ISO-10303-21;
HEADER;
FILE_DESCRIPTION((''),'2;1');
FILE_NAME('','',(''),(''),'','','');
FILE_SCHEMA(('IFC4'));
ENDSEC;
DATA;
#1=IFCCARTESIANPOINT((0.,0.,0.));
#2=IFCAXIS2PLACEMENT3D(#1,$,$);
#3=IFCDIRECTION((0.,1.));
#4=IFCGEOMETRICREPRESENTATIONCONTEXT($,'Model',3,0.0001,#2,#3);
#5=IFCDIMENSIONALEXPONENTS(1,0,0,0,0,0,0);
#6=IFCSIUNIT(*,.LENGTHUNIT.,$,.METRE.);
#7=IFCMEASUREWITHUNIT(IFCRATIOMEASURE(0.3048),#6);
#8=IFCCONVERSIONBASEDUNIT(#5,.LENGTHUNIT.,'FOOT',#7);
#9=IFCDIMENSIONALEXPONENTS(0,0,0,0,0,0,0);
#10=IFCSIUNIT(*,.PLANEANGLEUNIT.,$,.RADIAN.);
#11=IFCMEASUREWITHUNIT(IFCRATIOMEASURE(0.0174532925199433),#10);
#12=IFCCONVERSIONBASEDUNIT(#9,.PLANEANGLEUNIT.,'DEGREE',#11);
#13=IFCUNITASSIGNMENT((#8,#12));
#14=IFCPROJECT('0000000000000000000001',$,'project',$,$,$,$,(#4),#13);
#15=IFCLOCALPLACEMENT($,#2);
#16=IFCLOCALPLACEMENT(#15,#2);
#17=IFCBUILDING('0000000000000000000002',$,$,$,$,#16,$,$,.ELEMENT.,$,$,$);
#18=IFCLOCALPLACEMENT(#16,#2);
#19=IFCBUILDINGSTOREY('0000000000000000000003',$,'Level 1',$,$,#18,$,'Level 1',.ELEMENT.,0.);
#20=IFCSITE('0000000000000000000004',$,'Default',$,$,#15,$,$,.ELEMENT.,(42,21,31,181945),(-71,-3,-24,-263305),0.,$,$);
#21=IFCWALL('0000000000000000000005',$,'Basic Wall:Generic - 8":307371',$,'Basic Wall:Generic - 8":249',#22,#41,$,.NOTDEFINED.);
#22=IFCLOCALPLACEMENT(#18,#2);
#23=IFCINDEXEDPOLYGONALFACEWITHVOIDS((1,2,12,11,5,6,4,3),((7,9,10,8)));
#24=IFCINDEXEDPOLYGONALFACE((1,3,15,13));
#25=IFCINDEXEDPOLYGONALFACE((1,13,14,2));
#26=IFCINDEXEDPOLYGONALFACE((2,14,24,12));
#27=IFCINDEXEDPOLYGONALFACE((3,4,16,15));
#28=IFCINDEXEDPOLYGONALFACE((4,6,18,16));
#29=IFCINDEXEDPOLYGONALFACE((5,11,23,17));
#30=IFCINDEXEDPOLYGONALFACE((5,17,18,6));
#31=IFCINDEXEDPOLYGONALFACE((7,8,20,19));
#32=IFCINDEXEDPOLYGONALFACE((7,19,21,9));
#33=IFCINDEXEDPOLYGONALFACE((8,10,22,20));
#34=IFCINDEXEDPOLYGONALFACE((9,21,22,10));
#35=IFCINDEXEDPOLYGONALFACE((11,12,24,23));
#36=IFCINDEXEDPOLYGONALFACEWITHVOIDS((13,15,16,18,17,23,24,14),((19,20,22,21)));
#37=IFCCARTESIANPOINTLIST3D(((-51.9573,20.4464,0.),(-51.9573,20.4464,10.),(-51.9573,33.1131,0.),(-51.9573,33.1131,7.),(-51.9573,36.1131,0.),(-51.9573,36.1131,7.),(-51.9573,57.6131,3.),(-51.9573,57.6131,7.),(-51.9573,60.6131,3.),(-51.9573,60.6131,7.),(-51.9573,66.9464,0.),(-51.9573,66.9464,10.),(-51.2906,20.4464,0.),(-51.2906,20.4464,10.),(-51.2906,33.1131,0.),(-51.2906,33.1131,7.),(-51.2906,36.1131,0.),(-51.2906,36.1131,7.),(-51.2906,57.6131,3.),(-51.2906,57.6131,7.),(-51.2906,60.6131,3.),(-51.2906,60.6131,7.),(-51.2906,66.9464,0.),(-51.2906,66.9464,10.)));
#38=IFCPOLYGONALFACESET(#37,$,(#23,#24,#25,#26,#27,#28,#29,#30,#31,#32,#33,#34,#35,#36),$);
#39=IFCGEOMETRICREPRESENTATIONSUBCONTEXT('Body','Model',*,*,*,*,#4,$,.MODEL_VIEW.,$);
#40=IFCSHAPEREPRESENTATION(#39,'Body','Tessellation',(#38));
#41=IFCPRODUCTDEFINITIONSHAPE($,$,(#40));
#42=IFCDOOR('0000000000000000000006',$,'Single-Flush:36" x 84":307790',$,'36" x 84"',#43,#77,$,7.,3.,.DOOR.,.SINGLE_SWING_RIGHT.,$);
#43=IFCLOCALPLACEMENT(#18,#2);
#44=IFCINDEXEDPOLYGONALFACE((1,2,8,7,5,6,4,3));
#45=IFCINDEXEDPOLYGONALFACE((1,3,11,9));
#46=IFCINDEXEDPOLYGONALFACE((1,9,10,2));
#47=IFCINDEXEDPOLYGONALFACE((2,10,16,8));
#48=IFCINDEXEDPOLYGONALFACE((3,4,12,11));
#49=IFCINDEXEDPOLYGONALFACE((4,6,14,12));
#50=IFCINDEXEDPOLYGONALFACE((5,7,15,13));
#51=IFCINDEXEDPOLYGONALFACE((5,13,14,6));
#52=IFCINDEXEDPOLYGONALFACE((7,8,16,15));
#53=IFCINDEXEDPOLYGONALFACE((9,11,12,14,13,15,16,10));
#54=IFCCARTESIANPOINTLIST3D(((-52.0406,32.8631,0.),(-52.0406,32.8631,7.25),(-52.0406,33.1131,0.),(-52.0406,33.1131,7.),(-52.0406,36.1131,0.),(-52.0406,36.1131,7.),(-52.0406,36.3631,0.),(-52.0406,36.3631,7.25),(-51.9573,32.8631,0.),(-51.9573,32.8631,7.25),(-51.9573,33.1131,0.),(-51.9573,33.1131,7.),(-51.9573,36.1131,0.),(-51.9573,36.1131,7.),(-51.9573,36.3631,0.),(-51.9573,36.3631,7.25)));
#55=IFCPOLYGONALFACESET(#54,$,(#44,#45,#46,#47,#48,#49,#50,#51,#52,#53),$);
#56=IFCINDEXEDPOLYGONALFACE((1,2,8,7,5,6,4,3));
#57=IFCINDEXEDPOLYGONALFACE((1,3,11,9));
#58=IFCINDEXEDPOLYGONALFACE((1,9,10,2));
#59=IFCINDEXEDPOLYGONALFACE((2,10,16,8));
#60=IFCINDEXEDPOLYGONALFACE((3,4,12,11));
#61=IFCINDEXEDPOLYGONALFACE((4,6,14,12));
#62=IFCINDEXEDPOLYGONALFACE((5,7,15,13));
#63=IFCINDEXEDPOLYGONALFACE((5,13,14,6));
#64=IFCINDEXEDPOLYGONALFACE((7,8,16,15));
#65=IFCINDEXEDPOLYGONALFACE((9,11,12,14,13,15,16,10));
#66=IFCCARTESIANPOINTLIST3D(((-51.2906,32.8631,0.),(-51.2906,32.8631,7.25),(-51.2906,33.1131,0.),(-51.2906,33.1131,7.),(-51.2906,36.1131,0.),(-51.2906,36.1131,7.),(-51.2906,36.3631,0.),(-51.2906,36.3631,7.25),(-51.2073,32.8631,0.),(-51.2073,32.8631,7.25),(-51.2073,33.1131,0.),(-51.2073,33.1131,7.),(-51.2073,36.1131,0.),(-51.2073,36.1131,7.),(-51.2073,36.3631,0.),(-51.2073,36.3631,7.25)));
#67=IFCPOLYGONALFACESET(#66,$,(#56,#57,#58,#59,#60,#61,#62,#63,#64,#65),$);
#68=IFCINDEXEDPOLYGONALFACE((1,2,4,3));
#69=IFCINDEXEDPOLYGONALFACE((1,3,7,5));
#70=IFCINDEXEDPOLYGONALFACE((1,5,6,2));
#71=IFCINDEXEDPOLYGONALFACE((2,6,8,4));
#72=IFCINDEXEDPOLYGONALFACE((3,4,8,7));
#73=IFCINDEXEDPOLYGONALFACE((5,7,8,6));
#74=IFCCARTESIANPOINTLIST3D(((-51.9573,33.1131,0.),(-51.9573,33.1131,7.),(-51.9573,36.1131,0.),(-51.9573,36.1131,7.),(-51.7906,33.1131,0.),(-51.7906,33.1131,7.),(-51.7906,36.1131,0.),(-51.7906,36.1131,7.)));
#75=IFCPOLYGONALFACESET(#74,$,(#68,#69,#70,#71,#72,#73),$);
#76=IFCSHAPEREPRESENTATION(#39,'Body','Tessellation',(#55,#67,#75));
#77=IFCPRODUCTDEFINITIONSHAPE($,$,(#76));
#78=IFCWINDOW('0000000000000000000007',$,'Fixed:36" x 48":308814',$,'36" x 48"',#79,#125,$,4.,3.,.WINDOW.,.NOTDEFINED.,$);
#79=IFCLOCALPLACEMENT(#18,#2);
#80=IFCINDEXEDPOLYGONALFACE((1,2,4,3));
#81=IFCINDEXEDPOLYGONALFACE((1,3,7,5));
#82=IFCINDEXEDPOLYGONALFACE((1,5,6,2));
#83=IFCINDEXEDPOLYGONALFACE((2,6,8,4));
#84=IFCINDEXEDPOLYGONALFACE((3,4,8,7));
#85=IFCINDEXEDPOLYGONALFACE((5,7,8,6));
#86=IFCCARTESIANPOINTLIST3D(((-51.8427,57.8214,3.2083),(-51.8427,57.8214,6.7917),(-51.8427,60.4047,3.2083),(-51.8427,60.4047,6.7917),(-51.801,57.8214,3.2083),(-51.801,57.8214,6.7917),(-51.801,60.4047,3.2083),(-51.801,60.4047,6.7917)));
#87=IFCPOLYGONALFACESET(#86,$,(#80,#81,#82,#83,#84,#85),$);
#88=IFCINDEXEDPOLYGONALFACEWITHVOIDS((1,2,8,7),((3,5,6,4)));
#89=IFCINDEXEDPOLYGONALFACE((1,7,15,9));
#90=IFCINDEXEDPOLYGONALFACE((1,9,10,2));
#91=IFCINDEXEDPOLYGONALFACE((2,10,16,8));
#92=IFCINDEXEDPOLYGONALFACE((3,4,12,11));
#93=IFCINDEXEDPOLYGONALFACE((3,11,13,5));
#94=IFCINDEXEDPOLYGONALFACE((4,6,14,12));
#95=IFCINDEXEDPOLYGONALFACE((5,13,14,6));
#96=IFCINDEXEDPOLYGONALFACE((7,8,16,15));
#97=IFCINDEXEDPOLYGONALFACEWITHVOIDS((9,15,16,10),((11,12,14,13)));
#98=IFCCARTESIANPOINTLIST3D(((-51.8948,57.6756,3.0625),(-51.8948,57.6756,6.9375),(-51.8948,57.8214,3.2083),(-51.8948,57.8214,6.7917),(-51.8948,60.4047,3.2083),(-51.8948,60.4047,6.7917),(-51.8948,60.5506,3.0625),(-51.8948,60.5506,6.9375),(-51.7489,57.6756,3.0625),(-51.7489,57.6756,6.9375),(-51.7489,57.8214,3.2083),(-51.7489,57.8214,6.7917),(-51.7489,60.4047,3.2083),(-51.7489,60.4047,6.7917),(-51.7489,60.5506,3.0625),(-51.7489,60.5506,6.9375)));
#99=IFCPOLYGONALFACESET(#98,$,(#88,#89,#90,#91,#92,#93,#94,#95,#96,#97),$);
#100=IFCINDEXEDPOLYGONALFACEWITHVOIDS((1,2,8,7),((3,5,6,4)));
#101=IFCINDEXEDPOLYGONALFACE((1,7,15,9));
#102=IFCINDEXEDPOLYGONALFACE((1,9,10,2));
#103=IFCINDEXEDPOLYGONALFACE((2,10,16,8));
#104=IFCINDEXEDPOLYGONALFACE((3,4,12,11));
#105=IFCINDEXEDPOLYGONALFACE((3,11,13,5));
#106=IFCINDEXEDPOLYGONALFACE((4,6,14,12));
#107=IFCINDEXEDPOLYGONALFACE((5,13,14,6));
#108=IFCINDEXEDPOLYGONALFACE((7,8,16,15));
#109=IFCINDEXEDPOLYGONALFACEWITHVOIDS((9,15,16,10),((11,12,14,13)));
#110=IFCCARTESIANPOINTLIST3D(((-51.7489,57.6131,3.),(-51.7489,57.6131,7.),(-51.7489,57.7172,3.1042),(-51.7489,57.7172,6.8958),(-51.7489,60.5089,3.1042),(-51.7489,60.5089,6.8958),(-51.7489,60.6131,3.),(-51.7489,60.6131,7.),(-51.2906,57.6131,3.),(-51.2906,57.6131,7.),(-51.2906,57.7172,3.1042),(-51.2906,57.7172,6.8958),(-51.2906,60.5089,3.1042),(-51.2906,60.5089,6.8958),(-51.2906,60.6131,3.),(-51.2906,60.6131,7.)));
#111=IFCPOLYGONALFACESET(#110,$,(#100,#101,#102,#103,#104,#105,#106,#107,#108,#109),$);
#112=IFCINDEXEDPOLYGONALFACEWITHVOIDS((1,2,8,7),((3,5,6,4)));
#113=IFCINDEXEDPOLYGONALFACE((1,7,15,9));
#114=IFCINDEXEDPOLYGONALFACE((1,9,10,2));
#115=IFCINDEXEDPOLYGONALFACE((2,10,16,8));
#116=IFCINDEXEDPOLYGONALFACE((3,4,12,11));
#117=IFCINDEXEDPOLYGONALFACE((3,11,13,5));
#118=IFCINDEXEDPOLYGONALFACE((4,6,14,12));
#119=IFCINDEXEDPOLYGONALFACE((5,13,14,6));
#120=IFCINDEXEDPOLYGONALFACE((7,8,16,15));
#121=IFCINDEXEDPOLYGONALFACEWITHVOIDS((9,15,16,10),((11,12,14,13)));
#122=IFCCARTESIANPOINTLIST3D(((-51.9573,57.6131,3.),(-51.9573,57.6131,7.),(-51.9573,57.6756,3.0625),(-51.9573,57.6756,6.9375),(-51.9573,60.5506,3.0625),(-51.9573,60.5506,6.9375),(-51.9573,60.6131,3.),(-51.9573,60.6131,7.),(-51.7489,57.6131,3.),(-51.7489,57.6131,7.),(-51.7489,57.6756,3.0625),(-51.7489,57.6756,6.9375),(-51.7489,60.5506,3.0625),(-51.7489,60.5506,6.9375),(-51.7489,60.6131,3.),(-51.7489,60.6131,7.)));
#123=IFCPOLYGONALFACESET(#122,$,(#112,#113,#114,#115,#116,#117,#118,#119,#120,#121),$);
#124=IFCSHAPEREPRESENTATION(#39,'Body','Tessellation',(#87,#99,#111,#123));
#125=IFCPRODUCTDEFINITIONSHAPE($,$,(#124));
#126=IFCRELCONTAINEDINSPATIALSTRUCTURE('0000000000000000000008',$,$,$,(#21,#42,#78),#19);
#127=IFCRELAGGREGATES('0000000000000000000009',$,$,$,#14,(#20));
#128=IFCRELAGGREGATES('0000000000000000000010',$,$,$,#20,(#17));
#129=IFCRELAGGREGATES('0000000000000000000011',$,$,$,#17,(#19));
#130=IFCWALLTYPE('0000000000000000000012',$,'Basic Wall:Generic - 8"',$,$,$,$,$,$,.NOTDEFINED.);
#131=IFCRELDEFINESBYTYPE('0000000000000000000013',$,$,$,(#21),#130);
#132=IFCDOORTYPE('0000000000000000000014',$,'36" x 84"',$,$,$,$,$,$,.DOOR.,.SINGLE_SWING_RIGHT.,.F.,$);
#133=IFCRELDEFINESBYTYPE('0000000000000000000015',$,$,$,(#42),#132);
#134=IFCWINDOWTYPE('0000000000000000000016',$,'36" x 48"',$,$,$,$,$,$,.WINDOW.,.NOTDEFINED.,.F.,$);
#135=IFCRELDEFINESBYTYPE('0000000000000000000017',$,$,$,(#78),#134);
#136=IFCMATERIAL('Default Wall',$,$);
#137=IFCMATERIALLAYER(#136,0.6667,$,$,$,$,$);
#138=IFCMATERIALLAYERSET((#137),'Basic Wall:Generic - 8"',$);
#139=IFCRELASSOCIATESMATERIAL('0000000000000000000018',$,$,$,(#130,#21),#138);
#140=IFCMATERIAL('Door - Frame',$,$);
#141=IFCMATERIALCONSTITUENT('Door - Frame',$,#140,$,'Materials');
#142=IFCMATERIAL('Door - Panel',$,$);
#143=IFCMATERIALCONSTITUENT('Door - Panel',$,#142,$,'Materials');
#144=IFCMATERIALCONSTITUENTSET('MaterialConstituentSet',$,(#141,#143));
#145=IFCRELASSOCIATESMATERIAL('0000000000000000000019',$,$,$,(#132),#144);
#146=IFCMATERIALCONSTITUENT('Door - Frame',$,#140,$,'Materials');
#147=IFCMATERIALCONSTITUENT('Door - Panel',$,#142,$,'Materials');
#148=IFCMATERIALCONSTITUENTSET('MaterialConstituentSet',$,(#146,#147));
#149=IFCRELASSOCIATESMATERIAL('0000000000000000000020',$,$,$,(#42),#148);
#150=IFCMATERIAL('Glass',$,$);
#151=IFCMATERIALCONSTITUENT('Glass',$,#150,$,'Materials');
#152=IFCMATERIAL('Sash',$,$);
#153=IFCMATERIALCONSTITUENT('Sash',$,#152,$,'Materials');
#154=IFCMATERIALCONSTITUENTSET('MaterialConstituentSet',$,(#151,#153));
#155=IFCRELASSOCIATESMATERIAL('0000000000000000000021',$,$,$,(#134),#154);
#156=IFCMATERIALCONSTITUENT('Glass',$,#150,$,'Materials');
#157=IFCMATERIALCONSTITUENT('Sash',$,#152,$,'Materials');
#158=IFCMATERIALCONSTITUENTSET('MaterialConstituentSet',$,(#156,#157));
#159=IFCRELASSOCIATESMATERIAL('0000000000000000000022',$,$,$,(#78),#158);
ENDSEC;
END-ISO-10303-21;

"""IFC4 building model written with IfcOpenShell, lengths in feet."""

from ifc_helpers import new_model, entity, si_unit, converted_unit, direction, frame, frame_2d, origin, place, context, subcontext, project, spatial, polyline, rectangle, outline, extrude, source, transform, mapped, material, layer, layer_set, layer_usage, constituent, constituent_set, type_object, type_shapes, element, fill, save


model = new_model("IFC4")

# Units and contexts
model_context = context("Model", 3, precision=0.0001, world=origin(), true_north=direction((0.0, 1.0)))
body_context = subcontext(model_context, "Body", "Model", "MODEL_VIEW")
ifc_project = project(units=[converted_unit("LENGTHUNIT", "FOOT", entity("IfcRatioMeasure", 0.3048), si_unit("LENGTHUNIT", "METRE"), dimensions=[1, 0, 0, 0, 0, 0, 0]), converted_unit("PLANEANGLEUNIT", "DEGREE", entity("IfcRatioMeasure", 0.0174532925199433), si_unit("PLANEANGLEUNIT", "RADIAN"), dimensions=[0, 0, 0, 0, 0, 0, 0])], contexts=[model_context])

# Site, building, storey
site_placement = place(None, origin())
site = spatial("IfcSite", under=ifc_project, at=site_placement, Name="Default", CompositionType="ELEMENT", RefLatitude=(42, 21, 31, 181945), RefLongitude=(-71, -3, -24, -263305), RefElevation=0.0)
building_placement = place(site_placement, origin())
building = spatial("IfcBuilding", under=site, at=building_placement, CompositionType="ELEMENT")
storey_placement = place(building_placement, origin())
storey = spatial("IfcBuildingStorey", under=building, at=storey_placement, Name="Level 1", LongName="Level 1", CompositionType="ELEMENT", Elevation=0.0)

# Wall, openings, door, window
ifc_material_1 = material(Name="Default Wall")
ifc_layer = layer(ifc_material_1, 0.6667)
ifc_layer_set = layer_set([ifc_layer], Name="Basic Wall:Generic - 8\"")
ifc_layer_usage_1 = layer_usage(ifc_layer_set, "AXIS2", "NEGATIVE", 0.3333)
wall_type = type_object("IfcWallType", Name="Basic Wall:Generic - 8\"", PredefinedType="NOTDEFINED", material=ifc_layer_set)
wall_1_placement = place(storey_placement, frame((-51.6239, 66.9464, 0.0), z_axis=(0.0, 0.0, 1.0), x_axis=(0.0, -1.0, 0.0)))
wall_1 = element("IfcWall", 1, at=wall_1_placement, inside=storey, type_object=wall_type, material=ifc_layer_usage_1, Name="Basic Wall:Generic - 8\":307371", ObjectType="Basic Wall:Generic - 8\":249", PredefinedType="NOTDEFINED", context=body_context, shape_type="SweptSolid", body=[
    extrude(rectangle(XDim=46.5, YDim=0.6667, at=frame_2d((23.25, 0.0), x_axis=(-1.0, 0.0))), origin(), (0.0, 0.0, 1.0), 10.0),
])
opening_1_placement = place(wall_1_placement, frame((33.8333, 0.3333, 0.0)))
opening_1 = element("IfcOpeningElement", 2, at=opening_1_placement, cuts=wall_1, ObjectType="Opening", PredefinedType="OPENING", context=body_context, shape_type="SweptSolid", body=[
    extrude(rectangle(XDim=3.0, YDim=7.0, at=frame_2d((3.5, 1.5), x_axis=(0.0, 1.0))), frame((0.0, 0.0, 0.0), z_axis=(0.0, -1.0, 0.0), x_axis=(0.0, 0.0, 1.0)), (0.0, 0.0, 1.0), 0.6667),
])
opening_2_placement = place(wall_1_placement, frame((9.3333, 0.3333, 3.0)))
opening_2 = element("IfcOpeningElement", 3, at=opening_2_placement, cuts=wall_1, ObjectType="Opening", PredefinedType="OPENING", context=body_context, shape_type="SweptSolid", body=[
    extrude(rectangle(XDim=4.0, YDim=3.0, at=frame_2d((2.0, 1.5), x_axis=(-1.0, 0.0))), frame((0.0, 0.0, 0.0), z_axis=(0.0, -1.0, 0.0), x_axis=(0.0, 0.0, 1.0)), (0.0, 0.0, 1.0), 0.6667),
])
ifc_material_2 = material(Name="Door - Frame")
ifc_constituent_1 = constituent(ifc_material_2, Name="Door - Frame", Category="Materials")
ifc_material_3 = material(Name="Door - Panel")
ifc_constituent_2 = constituent(ifc_material_3, Name="Door - Panel", Category="Materials")
ifc_constituent_set_1 = constituent_set(constituents=[ifc_constituent_1, ifc_constituent_2], Name="MaterialConstituentSet")
ifc_constituent_3 = constituent(ifc_material_2, Name="Door - Frame", Category="Materials")
ifc_constituent_4 = constituent(ifc_material_3, Name="Door - Panel", Category="Materials")
ifc_constituent_set_2 = constituent_set(constituents=[ifc_constituent_3, ifc_constituent_4], Name="MaterialConstituentSet")
door_type = type_object("IfcDoorType", Name="36\" x 84\"", OperationType="SINGLE_SWING_RIGHT", ParameterTakesPrecedence=False, PredefinedType="DOOR", material=ifc_constituent_set_2)
shared_shape_1 = source(origin(), body_context, "Body", "SweptSolid", [
    extrude(outline(polyline([(-1.75, -3.6875), (1.75, -3.6875), (1.75, 3.5625), (1.5, 3.5625), (1.5, -3.4375), (-1.5, -3.4375), (-1.5, 3.5625), (-1.75, 3.5625), (-1.75, -3.6875)])), frame((1.5, 0.6667, 3.5625), z_axis=(0.0, 1.0, 0.0), x_axis=(1.0, 0.0, 0.0)), (0.0, 0.0, 1.0), 0.0833),
    extrude(outline(polyline([(-3.6875, -1.75), (3.5625, -1.75), (3.5625, -1.5), (-3.4375, -1.5), (-3.4375, 1.5), (3.5625, 1.5), (3.5625, 1.75), (-3.6875, 1.75), (-3.6875, -1.75)])), frame((1.5, -0.0833, 3.5625), z_axis=(0.0, 1.0, 0.0), x_axis=(0.0, 0.0, -1.0)), (0.0, 0.0, 1.0), 0.0833),
    extrude(rectangle(XDim=0.1667, YDim=3.0, at=frame_2d((0.0, 0.0), x_axis=(1.0, 0.0))), frame((1.5, 0.5833, 0.0), z_axis=(0.0, 0.0, 1.0), x_axis=(0.0, 1.0, 0.0)), (0.0, 0.0, 1.0), 7.0),
])
type_shapes(door_type, [shared_shape_1])
door_1_placement = place(opening_1_placement, frame((0.0, 0.0, 0.0), z_axis=(0.0, 0.0, 1.0), x_axis=(-1.0, 0.0, 0.0)))
door_1 = element("IfcDoor", 4, at=door_1_placement, inside=storey, type_object=door_type, material=ifc_constituent_set_1, Name="Single-Flush:36\" x 84\":307790", ObjectType="36\" x 84\"", OperationType="SINGLE_SWING_RIGHT", OverallHeight=7.0, OverallWidth=3.0, PredefinedType="DOOR", context=body_context, shape_type="MappedRepresentation", body=[
    mapped(shared_shape_1, transform((0.0, 0.0, 0.0), scale=1.0)),
])
fill(opening_1, door_1)
ifc_material_4 = material(Name="Glass")
ifc_constituent_5 = constituent(ifc_material_4, Name="Glass", Category="Materials")
ifc_material_5 = material(Name="Sash")
ifc_constituent_6 = constituent(ifc_material_5, Name="Sash", Category="Materials")
ifc_constituent_set_3 = constituent_set(constituents=[ifc_constituent_5, ifc_constituent_6], Name="MaterialConstituentSet")
ifc_constituent_7 = constituent(ifc_material_4, Name="Glass", Category="Materials")
ifc_constituent_8 = constituent(ifc_material_5, Name="Sash", Category="Materials")
ifc_constituent_set_4 = constituent_set(constituents=[ifc_constituent_7, ifc_constituent_8], Name="MaterialConstituentSet")
window_type_1 = type_object("IfcWindowType", Name="36\" x 48\"", ParameterTakesPrecedence=False, PartitioningType="NOTDEFINED", PredefinedType="WINDOW", material=ifc_constituent_set_4)
shared_shape_2 = source(origin(), body_context, "Body", "SweptSolid", [
    extrude(rectangle(XDim=0.0417, YDim=2.5833, at=frame_2d((0.0, 0.0), x_axis=(1.0, 0.0))), frame((1.5, 0.5312, 0.2083), z_axis=(0.0, 0.0, 1.0), x_axis=(0.0, 1.0, 0.0)), (0.0, 0.0, 1.0), 3.5833),
    extrude(outline(polyline([(-1.4375, -1.9375), (1.4375, -1.9375), (1.4375, 1.9375), (-1.4375, 1.9375), (-1.4375, -1.9375)]), holes=[polyline([(-1.2917, -1.7917), (-1.2917, 1.7917), (1.2917, 1.7917), (1.2917, -1.7917), (-1.2917, -1.7917)])]), frame((1.5, 0.4583, 2.0), z_axis=(0.0, 1.0, 0.0), x_axis=(1.0, 0.0, 0.0)), (0.0, 0.0, 1.0), 0.1458),
    extrude(outline(polyline([(-1.5, -2.0), (1.5, -2.0), (1.5, 2.0), (-1.5, 2.0), (-1.5, -2.0)]), holes=[polyline([(-1.3958, -1.8958), (-1.3958, 1.8958), (1.3958, 1.8958), (1.3958, -1.8958), (-1.3958, -1.8958)])]), frame((1.5, 0.0, 2.0), z_axis=(0.0, 1.0, 0.0), x_axis=(1.0, 0.0, 0.0)), (0.0, 0.0, 1.0), 0.4583),
    extrude(outline(polyline([(-2.0, -1.5), (2.0, -1.5), (2.0, 1.5), (-2.0, 1.5), (-2.0, -1.5)]), holes=[polyline([(-1.9375, -1.4375), (-1.9375, 1.4375), (1.9375, 1.4375), (1.9375, -1.4375), (-1.9375, -1.4375)])]), frame((1.5, 0.4583, 2.0), z_axis=(0.0, 1.0, 0.0), x_axis=(0.0, 0.0, -1.0)), (0.0, 0.0, 1.0), 0.2083),
])
type_shapes(window_type_1, [shared_shape_2])
window_1_placement = place(opening_2_placement, frame((0.0, 0.0, 0.0), z_axis=(0.0, 0.0, 1.0), x_axis=(-1.0, 0.0, 0.0)))
window_1 = element("IfcWindow", 5, at=window_1_placement, inside=storey, type_object=window_type_1, material=ifc_constituent_set_3, Name="Fixed:36\" x 48\":308814", ObjectType="36\" x 48\"", OverallHeight=4.0, OverallWidth=3.0, PartitioningType="NOTDEFINED", PredefinedType="WINDOW", context=body_context, shape_type="MappedRepresentation", body=[
    mapped(shared_shape_2, transform((0.0, 0.0, 0.0), scale=1.0)),
])
fill(opening_2, window_1)

save(model, "model.ifc")
